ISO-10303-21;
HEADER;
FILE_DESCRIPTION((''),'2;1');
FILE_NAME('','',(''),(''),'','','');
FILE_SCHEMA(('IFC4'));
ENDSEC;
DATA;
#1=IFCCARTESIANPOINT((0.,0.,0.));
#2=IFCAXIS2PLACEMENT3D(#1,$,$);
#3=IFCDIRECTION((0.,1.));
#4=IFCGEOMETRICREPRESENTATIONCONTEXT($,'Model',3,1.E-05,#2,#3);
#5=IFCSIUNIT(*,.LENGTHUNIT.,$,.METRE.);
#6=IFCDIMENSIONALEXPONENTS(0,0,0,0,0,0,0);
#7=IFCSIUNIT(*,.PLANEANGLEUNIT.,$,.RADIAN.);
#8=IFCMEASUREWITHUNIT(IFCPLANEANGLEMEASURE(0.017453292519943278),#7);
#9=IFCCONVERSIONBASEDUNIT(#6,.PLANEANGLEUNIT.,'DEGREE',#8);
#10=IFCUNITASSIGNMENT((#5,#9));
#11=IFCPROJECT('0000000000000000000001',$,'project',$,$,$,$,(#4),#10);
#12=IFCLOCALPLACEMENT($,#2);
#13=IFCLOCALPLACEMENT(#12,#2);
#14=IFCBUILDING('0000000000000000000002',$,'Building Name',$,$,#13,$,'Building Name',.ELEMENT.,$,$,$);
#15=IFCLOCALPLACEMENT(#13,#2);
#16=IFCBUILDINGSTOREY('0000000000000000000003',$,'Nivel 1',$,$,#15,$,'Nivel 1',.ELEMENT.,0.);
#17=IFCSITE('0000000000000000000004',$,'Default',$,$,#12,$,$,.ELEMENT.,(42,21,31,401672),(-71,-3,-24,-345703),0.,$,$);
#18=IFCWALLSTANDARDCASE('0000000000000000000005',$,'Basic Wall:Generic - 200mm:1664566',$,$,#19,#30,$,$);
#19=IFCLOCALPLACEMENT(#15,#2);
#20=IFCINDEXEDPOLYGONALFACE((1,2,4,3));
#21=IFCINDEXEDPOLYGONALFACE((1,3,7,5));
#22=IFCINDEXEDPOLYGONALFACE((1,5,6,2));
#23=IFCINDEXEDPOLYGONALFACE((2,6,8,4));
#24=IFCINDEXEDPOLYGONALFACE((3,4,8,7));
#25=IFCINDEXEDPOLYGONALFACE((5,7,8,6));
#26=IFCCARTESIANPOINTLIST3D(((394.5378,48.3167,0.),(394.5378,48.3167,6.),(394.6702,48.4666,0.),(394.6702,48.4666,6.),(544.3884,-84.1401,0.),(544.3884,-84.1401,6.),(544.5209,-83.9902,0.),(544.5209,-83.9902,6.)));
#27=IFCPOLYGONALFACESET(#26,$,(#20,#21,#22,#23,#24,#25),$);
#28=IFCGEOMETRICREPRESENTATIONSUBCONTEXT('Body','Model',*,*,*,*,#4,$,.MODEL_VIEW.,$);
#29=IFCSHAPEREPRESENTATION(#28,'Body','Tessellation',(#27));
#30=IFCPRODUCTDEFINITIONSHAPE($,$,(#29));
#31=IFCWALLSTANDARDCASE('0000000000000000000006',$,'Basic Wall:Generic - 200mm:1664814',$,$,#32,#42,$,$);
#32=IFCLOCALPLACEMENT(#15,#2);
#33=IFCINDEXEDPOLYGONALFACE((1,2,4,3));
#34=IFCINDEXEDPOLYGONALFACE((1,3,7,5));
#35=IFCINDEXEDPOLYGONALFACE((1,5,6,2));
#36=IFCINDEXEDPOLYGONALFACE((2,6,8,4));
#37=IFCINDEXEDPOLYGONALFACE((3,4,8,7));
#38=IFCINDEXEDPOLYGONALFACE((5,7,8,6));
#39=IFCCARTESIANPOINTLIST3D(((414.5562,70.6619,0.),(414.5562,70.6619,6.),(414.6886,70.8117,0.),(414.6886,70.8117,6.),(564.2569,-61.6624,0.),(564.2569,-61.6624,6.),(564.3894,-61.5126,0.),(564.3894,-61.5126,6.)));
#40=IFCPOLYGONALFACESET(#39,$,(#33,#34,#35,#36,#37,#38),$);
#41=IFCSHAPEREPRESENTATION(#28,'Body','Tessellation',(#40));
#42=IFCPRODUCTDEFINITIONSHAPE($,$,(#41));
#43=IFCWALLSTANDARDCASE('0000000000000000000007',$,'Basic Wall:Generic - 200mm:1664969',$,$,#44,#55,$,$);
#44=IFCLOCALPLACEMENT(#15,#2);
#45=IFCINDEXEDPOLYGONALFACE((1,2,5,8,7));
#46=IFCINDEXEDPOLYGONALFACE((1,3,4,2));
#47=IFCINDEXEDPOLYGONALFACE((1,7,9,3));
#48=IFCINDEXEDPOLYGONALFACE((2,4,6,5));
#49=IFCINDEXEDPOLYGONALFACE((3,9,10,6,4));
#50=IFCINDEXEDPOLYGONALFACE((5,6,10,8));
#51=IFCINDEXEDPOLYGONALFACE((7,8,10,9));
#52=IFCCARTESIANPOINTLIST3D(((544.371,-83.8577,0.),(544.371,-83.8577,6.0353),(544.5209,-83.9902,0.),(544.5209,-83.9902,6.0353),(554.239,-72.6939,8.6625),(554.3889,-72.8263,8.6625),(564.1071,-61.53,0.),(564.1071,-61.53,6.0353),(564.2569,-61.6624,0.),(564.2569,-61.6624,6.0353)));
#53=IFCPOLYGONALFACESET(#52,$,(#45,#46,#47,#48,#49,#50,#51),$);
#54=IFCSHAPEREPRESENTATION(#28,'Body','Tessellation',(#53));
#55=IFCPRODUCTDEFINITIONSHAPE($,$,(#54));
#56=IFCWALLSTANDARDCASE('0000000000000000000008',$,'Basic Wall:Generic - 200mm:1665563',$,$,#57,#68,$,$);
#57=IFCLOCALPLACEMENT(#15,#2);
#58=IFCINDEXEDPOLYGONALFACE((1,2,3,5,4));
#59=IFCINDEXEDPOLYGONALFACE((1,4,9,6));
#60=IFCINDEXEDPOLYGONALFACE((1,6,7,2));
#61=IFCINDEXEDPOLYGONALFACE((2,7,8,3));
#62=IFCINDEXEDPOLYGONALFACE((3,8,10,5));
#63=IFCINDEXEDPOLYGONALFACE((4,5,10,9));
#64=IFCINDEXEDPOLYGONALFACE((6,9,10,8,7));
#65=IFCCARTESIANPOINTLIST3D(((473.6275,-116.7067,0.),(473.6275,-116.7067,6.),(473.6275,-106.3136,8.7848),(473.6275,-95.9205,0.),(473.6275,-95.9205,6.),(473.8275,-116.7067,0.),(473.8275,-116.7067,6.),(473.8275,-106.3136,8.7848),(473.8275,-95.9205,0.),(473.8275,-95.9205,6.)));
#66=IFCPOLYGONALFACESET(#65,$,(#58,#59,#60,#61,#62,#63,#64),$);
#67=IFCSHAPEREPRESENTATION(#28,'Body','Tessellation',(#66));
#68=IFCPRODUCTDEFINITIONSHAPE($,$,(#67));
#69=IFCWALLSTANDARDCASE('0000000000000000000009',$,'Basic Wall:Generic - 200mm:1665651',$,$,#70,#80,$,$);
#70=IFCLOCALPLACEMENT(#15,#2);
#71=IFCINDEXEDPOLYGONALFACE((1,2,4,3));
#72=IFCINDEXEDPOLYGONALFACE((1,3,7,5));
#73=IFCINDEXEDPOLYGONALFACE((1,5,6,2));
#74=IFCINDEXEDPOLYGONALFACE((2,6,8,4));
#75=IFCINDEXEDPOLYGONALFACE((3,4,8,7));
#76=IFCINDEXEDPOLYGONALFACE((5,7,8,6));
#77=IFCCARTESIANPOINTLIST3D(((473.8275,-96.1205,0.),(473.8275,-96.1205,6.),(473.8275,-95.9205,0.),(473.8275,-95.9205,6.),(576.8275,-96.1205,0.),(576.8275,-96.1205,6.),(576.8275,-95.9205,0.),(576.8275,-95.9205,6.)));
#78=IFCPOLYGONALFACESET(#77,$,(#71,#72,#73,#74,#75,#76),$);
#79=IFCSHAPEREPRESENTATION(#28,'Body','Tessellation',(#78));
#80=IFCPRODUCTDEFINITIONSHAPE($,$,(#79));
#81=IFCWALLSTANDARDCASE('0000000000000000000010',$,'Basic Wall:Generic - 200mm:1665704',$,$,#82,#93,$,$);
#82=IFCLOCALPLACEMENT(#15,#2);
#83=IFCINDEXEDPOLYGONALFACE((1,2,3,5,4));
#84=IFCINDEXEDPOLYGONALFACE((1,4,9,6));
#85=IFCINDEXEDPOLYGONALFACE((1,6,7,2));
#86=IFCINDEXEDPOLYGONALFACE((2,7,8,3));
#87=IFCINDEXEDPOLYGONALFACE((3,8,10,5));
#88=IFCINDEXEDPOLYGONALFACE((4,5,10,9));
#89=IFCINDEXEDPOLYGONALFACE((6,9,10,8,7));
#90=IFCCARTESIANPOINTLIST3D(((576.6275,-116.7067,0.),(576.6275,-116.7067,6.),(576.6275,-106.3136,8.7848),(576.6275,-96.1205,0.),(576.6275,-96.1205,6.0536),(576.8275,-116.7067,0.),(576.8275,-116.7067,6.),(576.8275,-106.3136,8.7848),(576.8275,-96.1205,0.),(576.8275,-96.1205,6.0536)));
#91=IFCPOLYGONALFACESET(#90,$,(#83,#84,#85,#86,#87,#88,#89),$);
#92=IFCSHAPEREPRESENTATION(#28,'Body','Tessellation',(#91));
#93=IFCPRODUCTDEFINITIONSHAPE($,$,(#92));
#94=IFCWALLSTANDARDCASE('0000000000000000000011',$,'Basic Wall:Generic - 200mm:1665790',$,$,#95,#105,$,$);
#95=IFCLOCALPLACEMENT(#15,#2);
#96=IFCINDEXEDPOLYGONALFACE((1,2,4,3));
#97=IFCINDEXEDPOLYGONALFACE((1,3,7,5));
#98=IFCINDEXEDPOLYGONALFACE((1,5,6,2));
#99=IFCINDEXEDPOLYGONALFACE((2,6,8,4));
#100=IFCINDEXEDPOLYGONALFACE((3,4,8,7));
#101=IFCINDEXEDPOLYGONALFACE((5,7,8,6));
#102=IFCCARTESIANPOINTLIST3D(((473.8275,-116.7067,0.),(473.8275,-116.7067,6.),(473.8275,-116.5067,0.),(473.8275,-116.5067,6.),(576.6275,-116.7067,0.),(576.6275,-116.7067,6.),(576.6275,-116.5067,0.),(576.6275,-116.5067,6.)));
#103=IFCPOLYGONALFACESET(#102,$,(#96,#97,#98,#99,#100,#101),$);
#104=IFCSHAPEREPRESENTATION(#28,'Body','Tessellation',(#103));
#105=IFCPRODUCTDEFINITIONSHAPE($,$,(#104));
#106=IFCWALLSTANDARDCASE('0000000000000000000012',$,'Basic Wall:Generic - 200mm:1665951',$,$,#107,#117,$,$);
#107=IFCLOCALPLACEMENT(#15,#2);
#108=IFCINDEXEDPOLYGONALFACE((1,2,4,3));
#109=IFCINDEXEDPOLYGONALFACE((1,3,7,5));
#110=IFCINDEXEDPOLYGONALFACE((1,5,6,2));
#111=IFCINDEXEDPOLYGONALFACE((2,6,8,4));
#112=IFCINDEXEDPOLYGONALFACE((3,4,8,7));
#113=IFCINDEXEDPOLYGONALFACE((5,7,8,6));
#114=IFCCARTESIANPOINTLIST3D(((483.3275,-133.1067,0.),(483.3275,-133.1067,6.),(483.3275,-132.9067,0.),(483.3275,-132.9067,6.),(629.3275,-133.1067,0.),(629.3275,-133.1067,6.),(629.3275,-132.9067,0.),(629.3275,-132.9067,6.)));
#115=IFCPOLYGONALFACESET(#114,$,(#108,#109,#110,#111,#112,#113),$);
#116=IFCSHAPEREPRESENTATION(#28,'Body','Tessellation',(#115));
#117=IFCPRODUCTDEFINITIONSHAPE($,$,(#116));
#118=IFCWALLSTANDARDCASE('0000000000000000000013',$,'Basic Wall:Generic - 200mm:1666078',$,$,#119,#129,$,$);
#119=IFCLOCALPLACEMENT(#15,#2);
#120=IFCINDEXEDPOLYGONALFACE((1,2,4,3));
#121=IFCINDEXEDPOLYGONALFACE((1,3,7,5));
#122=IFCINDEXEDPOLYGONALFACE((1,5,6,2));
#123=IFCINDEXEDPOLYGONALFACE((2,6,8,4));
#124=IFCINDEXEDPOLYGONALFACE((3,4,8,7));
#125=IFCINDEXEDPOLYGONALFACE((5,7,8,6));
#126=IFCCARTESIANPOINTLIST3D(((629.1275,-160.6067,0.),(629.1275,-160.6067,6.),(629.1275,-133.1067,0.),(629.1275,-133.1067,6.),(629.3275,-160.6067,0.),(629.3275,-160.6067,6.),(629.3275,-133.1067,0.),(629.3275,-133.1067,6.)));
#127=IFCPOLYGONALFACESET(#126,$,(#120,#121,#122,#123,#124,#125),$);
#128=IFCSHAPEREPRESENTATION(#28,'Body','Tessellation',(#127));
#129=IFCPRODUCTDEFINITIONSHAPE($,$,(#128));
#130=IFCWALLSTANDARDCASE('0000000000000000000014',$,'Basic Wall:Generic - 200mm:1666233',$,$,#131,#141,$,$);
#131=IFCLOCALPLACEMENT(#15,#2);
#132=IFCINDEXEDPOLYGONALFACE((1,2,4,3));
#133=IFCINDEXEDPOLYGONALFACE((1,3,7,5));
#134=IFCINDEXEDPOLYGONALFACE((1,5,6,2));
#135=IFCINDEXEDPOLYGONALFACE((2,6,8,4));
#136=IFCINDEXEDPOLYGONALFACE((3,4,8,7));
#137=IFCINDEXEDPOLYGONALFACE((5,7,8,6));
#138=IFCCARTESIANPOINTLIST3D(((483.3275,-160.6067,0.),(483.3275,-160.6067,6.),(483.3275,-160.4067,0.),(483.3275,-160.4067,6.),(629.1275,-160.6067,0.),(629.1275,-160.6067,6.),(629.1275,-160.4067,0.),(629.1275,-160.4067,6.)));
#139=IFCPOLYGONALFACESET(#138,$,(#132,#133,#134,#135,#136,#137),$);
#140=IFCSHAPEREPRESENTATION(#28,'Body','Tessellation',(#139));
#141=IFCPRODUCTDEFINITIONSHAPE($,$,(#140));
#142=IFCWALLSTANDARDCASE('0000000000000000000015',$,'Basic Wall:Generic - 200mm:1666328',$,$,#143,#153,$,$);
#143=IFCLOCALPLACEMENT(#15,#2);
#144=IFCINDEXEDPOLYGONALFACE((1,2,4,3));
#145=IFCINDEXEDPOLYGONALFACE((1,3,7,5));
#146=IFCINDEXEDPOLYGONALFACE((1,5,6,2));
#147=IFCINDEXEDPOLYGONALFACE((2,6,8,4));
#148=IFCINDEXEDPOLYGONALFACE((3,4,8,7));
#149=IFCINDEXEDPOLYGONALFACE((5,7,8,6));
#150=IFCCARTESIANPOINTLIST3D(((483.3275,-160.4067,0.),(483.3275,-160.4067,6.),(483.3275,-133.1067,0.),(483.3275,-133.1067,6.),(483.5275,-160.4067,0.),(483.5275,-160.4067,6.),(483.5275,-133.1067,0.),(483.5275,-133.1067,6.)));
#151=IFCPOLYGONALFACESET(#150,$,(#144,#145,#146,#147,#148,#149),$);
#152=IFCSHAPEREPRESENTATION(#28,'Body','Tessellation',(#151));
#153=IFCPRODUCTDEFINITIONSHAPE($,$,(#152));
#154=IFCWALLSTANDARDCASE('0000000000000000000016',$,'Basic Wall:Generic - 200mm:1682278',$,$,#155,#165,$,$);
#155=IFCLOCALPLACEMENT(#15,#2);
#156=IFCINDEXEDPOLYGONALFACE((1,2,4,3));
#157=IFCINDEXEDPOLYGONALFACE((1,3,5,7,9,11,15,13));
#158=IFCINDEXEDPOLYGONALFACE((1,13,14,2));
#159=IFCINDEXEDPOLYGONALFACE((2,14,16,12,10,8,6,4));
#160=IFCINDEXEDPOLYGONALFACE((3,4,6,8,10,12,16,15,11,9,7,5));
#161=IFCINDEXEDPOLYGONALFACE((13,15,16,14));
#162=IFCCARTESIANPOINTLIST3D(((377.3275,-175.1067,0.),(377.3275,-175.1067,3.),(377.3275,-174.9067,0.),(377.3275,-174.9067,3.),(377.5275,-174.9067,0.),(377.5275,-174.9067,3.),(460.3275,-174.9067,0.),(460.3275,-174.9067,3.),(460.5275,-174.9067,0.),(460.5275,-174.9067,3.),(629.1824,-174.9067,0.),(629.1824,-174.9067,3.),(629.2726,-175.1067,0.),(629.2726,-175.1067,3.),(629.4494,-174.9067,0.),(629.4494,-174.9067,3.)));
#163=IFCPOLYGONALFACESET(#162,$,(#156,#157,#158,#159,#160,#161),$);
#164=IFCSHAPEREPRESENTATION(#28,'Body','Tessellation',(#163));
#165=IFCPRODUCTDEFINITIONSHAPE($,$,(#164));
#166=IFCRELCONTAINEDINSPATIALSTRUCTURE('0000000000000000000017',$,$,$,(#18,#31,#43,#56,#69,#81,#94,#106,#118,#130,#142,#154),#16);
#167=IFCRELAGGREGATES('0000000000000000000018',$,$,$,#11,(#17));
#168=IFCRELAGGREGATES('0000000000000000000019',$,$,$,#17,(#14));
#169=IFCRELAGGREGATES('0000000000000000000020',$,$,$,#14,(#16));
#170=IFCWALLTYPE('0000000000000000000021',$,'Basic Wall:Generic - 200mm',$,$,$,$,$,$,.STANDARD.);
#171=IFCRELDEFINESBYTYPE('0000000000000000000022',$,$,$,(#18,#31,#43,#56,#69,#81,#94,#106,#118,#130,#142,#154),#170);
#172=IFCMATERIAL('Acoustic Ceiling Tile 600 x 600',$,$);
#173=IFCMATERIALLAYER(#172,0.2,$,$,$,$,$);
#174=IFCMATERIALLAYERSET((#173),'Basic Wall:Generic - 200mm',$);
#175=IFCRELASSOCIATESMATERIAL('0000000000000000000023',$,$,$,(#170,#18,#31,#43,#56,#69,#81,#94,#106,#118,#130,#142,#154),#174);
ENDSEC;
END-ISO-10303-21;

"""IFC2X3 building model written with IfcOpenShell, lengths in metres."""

from ifc_helpers import new_model, entity, si_unit, converted_unit, direction, frame, frame_2d, origin, place, context, subcontext, project, spatial, polyline, rectangle, outline, extrude, clip, bounded_halfspace, material, layer, layer_set, layer_usage, type_object, element, save


model = new_model("IFC2X3")

# Units and contexts
model_context = context("Model", 3, precision=1e-05, world=origin(), true_north=direction((0.0, 1.0)))
body_context = subcontext(model_context, "Body", "Model", "MODEL_VIEW")
ifc_project = project(units=[si_unit("LENGTHUNIT", "METRE"), converted_unit("PLANEANGLEUNIT", "DEGREE", entity("IfcPlaneAngleMeasure", 0.017453292519943278), si_unit("PLANEANGLEUNIT", "RADIAN"), dimensions=[0, 0, 0, 0, 0, 0, 0])], contexts=[model_context])

# Site, building, storey
site_placement = place(None, origin())
site = spatial("IfcSite", under=ifc_project, at=site_placement, Name="Default", CompositionType="ELEMENT", RefLatitude=(42, 21, 31, 401672), RefLongitude=(-71, -3, -24, -345703), RefElevation=0.0)
building_placement = place(site_placement, origin())
building = spatial("IfcBuilding", under=site, at=building_placement, Name="Building Name", LongName="Building Name", CompositionType="ELEMENT")
storey_placement = place(building_placement, origin())
storey = spatial("IfcBuildingStorey", under=building, at=storey_placement, Name="Nivel 1", LongName="Nivel 1", CompositionType="ELEMENT", Elevation=0.0)

# Walls
ifc_material_1 = material(Name="Acoustic Ceiling Tile 600 x 600")
ifc_layer = layer(ifc_material_1, 0.2)
ifc_layer_set = layer_set([ifc_layer], Name="Basic Wall:Generic - 200mm")
ifc_layer_usage_1 = layer_usage(ifc_layer_set, "AXIS2", "NEGATIVE", 0.1)
wall_type_1 = type_object("IfcWallType", Name="Basic Wall:Generic - 200mm", PredefinedType="STANDARD", material=ifc_layer_set)
wall_1_placement = place(storey_placement, frame((544.4546, -84.0651, 0.0), z_axis=(0.0, 0.0, 1.0), x_axis=(-0.749253, 0.662284, 0.0)))
element("IfcWallStandardCase", 1, at=wall_1_placement, inside=storey, type_object=wall_type_1, material=ifc_layer_usage_1, Name="Basic Wall:Generic - 200mm:1664566", context=body_context, shape_type="SweptSolid", body=[
    extrude(rectangle(XDim=200.0, YDim=0.2, at=frame_2d((100.0, 0.0), x_axis=(-1.0, 0.0))), origin(), (0.0, 0.0, 1.0), 6.0),
])
ifc_layer_usage_2 = layer_usage(ifc_layer_set, "AXIS2", "NEGATIVE", 0.1)
wall_2_placement = place(storey_placement, frame((414.6224, 70.7368, 0.0), z_axis=(0.0, 0.0, 1.0), x_axis=(0.749253, -0.662284, 0.0)))
element("IfcWallStandardCase", 2, at=wall_2_placement, inside=storey, type_object=wall_type_1, material=ifc_layer_usage_2, Name="Basic Wall:Generic - 200mm:1664814", context=body_context, shape_type="SweptSolid", body=[
    extrude(rectangle(XDim=199.8, YDim=0.2, at=frame_2d((99.9, 0.0), x_axis=(-1.0, 0.0))), origin(), (0.0, 0.0, 1.0), 6.0),
])
ifc_layer_usage_3 = layer_usage(ifc_layer_set, "AXIS2", "NEGATIVE", 0.1)
wall_3_placement = place(storey_placement, frame((564.182, -61.5962, 0.0), z_axis=(0.0, 0.0, 1.0), x_axis=(-0.662284, -0.749253, 0.0)))
element("IfcWallStandardCase", 3, at=wall_3_placement, inside=storey, type_object=wall_type_1, material=ifc_layer_usage_3, Name="Basic Wall:Generic - 200mm:1664969", context=body_context, shape_type="Clipping", body=[
    clip(clip(extrude(rectangle(XDim=29.8, YDim=0.2, at=frame_2d((14.9, 0.0), x_axis=(-1.0, 0.0))), origin(), (0.0, 0.0, 1.0), 8.6625), bounded_halfspace(frame((0.0, -0.1, 6.0353), z_axis=(-0.173648, 0.0, 0.984808), x_axis=(0.0, -1.0, 0.0)), False, frame((0.0, -0.1, 6.0353)), polyline([(0.0, 0.0), (14.9, 0.0), (14.9, 0.2), (0.0, 0.2), (0.0, 0.0)]))), bounded_halfspace(frame((14.9, -0.1, 8.6625), z_axis=(0.173648, 0.0, 0.984808), x_axis=(0.0, 1.0, 0.0)), False, frame((14.9, -0.1, 8.6625)), polyline([(0.0, 0.0), (14.9, 0.0), (14.9, 0.2), (0.0, 0.2), (0.0, 0.0)]))),
])
ifc_layer_usage_4 = layer_usage(ifc_layer_set, "AXIS2", "NEGATIVE", 0.1)
wall_4_placement = place(storey_placement, frame((473.7275, -116.7067, 0.0), z_axis=(0.0, 0.0, 1.0), x_axis=(0.0, 1.0, 0.0)))
element("IfcWallStandardCase", 4, at=wall_4_placement, inside=storey, type_object=wall_type_1, material=ifc_layer_usage_4, Name="Basic Wall:Generic - 200mm:1665563", context=body_context, shape_type="Clipping", body=[
    clip(clip(extrude(rectangle(XDim=20.7862, YDim=0.2, at=frame_2d((10.3931, 0.0), x_axis=(-1.0, 0.0))), origin(), (0.0, 0.0, 1.0), 8.7848), bounded_halfspace(frame((10.3931, -0.1, 8.7848), z_axis=(0.258819, 0.0, 0.965926), x_axis=(0.0, 1.0, 0.0)), False, frame((10.3931, -0.1, 8.7848)), polyline([(0.0, 0.0), (10.3931, 0.0), (10.3931, 0.2), (0.0, 0.2), (0.0, 0.0)]))), bounded_halfspace(frame((0.0, -0.1, 6.0), z_axis=(-0.258819, 0.0, 0.965926), x_axis=(0.0, -1.0, 0.0)), False, frame((0.0, -0.1, 6.0)), polyline([(0.0, 0.0), (10.3931, 0.0), (10.3931, 0.2), (0.0, 0.2), (0.0, 0.0)]))),
])
ifc_layer_usage_5 = layer_usage(ifc_layer_set, "AXIS2", "NEGATIVE", 0.1)
wall_5_placement = place(storey_placement, frame((473.8275, -96.0205, 0.0)))
element("IfcWallStandardCase", 5, at=wall_5_placement, inside=storey, type_object=wall_type_1, material=ifc_layer_usage_5, Name="Basic Wall:Generic - 200mm:1665651", context=body_context, shape_type="SweptSolid", body=[
    extrude(rectangle(XDim=103.0, YDim=0.2, at=frame_2d((51.5, 0.0), x_axis=(-1.0, 0.0))), origin(), (0.0, 0.0, 1.0), 6.0),
])
ifc_layer_usage_6 = layer_usage(ifc_layer_set, "AXIS2", "NEGATIVE", 0.1)
wall_6_placement = place(storey_placement, frame((576.7275, -96.1205, 0.0), z_axis=(0.0, 0.0, 1.0), x_axis=(0.0, -1.0, 0.0)))
element("IfcWallStandardCase", 6, at=wall_6_placement, inside=storey, type_object=wall_type_1, material=ifc_layer_usage_6, Name="Basic Wall:Generic - 200mm:1665704", context=body_context, shape_type="Clipping", body=[
    clip(clip(extrude(rectangle(XDim=20.5862, YDim=0.2, at=frame_2d((10.2931, 0.0), x_axis=(-1.0, 0.0))), origin(), (0.0, 0.0, 1.0), 8.7848), bounded_halfspace(frame((0.0, -0.1, 6.0536), z_axis=(-0.258819, 0.0, 0.965926), x_axis=(0.0, -1.0, 0.0)), False, frame((0.0, -0.1, 6.0536)), polyline([(0.0, 0.0), (10.1931, 0.0), (10.1931, 0.2), (0.0, 0.2), (0.0, 0.0)]))), bounded_halfspace(frame((10.1931, -0.1, 8.7848), z_axis=(0.258819, 0.0, 0.965926), x_axis=(0.0, 1.0, 0.0)), False, frame((10.1931, -0.1, 8.7848)), polyline([(0.0, 0.0), (10.3931, 0.0), (10.3931, 0.2), (0.0, 0.2), (0.0, 0.0)]))),
])
ifc_layer_usage_7 = layer_usage(ifc_layer_set, "AXIS2", "NEGATIVE", 0.1)
wall_7_placement = place(storey_placement, frame((576.6275, -116.6067, 0.0), z_axis=(0.0, 0.0, 1.0), x_axis=(-1.0, 0.0, 0.0)))
element("IfcWallStandardCase", 7, at=wall_7_placement, inside=storey, type_object=wall_type_1, material=ifc_layer_usage_7, Name="Basic Wall:Generic - 200mm:1665790", context=body_context, shape_type="SweptSolid", body=[
    extrude(rectangle(XDim=102.8, YDim=0.2, at=frame_2d((51.4, 0.0), x_axis=(-1.0, 0.0))), origin(), (0.0, 0.0, 1.0), 6.0),
])
ifc_layer_usage_8 = layer_usage(ifc_layer_set, "AXIS2", "NEGATIVE", 0.1)
wall_8_placement = place(storey_placement, frame((483.3275, -133.0067, 0.0)))
element("IfcWallStandardCase", 8, at=wall_8_placement, inside=storey, type_object=wall_type_1, material=ifc_layer_usage_8, Name="Basic Wall:Generic - 200mm:1665951", context=body_context, shape_type="SweptSolid", body=[
    extrude(rectangle(XDim=146.0, YDim=0.2, at=frame_2d((73.0, 0.0), x_axis=(-1.0, 0.0))), origin(), (0.0, 0.0, 1.0), 6.0),
])
ifc_layer_usage_9 = layer_usage(ifc_layer_set, "AXIS2", "NEGATIVE", 0.1)
wall_9_placement = place(storey_placement, frame((629.2275, -133.1067, 0.0), z_axis=(0.0, 0.0, 1.0), x_axis=(0.0, -1.0, 0.0)))
element("IfcWallStandardCase", 9, at=wall_9_placement, inside=storey, type_object=wall_type_1, material=ifc_layer_usage_9, Name="Basic Wall:Generic - 200mm:1666078", context=body_context, shape_type="SweptSolid", body=[
    extrude(rectangle(XDim=27.5, YDim=0.2, at=frame_2d((13.75, 0.0), x_axis=(-1.0, 0.0))), origin(), (0.0, 0.0, 1.0), 6.0),
])
ifc_layer_usage_10 = layer_usage(ifc_layer_set, "AXIS2", "NEGATIVE", 0.1)
wall_10_placement = place(storey_placement, frame((629.1275, -160.5067, 0.0), z_axis=(0.0, 0.0, 1.0), x_axis=(-1.0, 0.0, 0.0)))
element("IfcWallStandardCase", 10, at=wall_10_placement, inside=storey, type_object=wall_type_1, material=ifc_layer_usage_10, Name="Basic Wall:Generic - 200mm:1666233", context=body_context, shape_type="SweptSolid", body=[
    extrude(rectangle(XDim=145.8, YDim=0.2, at=frame_2d((72.9, 0.0), x_axis=(-1.0, 0.0))), origin(), (0.0, 0.0, 1.0), 6.0),
])
ifc_layer_usage_11 = layer_usage(ifc_layer_set, "AXIS2", "NEGATIVE", 0.1)
wall_11_placement = place(storey_placement, frame((483.4275, -160.4067, 0.0), z_axis=(0.0, 0.0, 1.0), x_axis=(0.0, 1.0, 0.0)))
element("IfcWallStandardCase", 11, at=wall_11_placement, inside=storey, type_object=wall_type_1, material=ifc_layer_usage_11, Name="Basic Wall:Generic - 200mm:1666328", context=body_context, shape_type="SweptSolid", body=[
    extrude(rectangle(XDim=27.3, YDim=0.2, at=frame_2d((13.65, 0.0), x_axis=(-1.0, 0.0))), origin(), (0.0, 0.0, 1.0), 6.0),
])
ifc_layer_usage_12 = layer_usage(ifc_layer_set, "AXIS2", "NEGATIVE", 0.1)
wall_12_placement = place(storey_placement, frame((629.4494, -175.0067, 0.0), z_axis=(0.0, 0.0, 1.0), x_axis=(-1.0, 0.0, 0.0)))
element("IfcWallStandardCase", 12, at=wall_12_placement, inside=storey, type_object=wall_type_1, material=ifc_layer_usage_12, Name="Basic Wall:Generic - 200mm:1682278", context=body_context, shape_type="SweptSolid", body=[
    extrude(outline(polyline([(252.1219, -0.1), (252.1219, 0.1), (0.1768, 0.1), (0.0, -0.1), (0.2669, -0.1), (168.9219, -0.1), (169.1219, -0.1), (251.9219, -0.1), (252.1219, -0.1)])), origin(), (0.0, 0.0, 1.0), 3.0),
])

save(model, "model.ifc")
